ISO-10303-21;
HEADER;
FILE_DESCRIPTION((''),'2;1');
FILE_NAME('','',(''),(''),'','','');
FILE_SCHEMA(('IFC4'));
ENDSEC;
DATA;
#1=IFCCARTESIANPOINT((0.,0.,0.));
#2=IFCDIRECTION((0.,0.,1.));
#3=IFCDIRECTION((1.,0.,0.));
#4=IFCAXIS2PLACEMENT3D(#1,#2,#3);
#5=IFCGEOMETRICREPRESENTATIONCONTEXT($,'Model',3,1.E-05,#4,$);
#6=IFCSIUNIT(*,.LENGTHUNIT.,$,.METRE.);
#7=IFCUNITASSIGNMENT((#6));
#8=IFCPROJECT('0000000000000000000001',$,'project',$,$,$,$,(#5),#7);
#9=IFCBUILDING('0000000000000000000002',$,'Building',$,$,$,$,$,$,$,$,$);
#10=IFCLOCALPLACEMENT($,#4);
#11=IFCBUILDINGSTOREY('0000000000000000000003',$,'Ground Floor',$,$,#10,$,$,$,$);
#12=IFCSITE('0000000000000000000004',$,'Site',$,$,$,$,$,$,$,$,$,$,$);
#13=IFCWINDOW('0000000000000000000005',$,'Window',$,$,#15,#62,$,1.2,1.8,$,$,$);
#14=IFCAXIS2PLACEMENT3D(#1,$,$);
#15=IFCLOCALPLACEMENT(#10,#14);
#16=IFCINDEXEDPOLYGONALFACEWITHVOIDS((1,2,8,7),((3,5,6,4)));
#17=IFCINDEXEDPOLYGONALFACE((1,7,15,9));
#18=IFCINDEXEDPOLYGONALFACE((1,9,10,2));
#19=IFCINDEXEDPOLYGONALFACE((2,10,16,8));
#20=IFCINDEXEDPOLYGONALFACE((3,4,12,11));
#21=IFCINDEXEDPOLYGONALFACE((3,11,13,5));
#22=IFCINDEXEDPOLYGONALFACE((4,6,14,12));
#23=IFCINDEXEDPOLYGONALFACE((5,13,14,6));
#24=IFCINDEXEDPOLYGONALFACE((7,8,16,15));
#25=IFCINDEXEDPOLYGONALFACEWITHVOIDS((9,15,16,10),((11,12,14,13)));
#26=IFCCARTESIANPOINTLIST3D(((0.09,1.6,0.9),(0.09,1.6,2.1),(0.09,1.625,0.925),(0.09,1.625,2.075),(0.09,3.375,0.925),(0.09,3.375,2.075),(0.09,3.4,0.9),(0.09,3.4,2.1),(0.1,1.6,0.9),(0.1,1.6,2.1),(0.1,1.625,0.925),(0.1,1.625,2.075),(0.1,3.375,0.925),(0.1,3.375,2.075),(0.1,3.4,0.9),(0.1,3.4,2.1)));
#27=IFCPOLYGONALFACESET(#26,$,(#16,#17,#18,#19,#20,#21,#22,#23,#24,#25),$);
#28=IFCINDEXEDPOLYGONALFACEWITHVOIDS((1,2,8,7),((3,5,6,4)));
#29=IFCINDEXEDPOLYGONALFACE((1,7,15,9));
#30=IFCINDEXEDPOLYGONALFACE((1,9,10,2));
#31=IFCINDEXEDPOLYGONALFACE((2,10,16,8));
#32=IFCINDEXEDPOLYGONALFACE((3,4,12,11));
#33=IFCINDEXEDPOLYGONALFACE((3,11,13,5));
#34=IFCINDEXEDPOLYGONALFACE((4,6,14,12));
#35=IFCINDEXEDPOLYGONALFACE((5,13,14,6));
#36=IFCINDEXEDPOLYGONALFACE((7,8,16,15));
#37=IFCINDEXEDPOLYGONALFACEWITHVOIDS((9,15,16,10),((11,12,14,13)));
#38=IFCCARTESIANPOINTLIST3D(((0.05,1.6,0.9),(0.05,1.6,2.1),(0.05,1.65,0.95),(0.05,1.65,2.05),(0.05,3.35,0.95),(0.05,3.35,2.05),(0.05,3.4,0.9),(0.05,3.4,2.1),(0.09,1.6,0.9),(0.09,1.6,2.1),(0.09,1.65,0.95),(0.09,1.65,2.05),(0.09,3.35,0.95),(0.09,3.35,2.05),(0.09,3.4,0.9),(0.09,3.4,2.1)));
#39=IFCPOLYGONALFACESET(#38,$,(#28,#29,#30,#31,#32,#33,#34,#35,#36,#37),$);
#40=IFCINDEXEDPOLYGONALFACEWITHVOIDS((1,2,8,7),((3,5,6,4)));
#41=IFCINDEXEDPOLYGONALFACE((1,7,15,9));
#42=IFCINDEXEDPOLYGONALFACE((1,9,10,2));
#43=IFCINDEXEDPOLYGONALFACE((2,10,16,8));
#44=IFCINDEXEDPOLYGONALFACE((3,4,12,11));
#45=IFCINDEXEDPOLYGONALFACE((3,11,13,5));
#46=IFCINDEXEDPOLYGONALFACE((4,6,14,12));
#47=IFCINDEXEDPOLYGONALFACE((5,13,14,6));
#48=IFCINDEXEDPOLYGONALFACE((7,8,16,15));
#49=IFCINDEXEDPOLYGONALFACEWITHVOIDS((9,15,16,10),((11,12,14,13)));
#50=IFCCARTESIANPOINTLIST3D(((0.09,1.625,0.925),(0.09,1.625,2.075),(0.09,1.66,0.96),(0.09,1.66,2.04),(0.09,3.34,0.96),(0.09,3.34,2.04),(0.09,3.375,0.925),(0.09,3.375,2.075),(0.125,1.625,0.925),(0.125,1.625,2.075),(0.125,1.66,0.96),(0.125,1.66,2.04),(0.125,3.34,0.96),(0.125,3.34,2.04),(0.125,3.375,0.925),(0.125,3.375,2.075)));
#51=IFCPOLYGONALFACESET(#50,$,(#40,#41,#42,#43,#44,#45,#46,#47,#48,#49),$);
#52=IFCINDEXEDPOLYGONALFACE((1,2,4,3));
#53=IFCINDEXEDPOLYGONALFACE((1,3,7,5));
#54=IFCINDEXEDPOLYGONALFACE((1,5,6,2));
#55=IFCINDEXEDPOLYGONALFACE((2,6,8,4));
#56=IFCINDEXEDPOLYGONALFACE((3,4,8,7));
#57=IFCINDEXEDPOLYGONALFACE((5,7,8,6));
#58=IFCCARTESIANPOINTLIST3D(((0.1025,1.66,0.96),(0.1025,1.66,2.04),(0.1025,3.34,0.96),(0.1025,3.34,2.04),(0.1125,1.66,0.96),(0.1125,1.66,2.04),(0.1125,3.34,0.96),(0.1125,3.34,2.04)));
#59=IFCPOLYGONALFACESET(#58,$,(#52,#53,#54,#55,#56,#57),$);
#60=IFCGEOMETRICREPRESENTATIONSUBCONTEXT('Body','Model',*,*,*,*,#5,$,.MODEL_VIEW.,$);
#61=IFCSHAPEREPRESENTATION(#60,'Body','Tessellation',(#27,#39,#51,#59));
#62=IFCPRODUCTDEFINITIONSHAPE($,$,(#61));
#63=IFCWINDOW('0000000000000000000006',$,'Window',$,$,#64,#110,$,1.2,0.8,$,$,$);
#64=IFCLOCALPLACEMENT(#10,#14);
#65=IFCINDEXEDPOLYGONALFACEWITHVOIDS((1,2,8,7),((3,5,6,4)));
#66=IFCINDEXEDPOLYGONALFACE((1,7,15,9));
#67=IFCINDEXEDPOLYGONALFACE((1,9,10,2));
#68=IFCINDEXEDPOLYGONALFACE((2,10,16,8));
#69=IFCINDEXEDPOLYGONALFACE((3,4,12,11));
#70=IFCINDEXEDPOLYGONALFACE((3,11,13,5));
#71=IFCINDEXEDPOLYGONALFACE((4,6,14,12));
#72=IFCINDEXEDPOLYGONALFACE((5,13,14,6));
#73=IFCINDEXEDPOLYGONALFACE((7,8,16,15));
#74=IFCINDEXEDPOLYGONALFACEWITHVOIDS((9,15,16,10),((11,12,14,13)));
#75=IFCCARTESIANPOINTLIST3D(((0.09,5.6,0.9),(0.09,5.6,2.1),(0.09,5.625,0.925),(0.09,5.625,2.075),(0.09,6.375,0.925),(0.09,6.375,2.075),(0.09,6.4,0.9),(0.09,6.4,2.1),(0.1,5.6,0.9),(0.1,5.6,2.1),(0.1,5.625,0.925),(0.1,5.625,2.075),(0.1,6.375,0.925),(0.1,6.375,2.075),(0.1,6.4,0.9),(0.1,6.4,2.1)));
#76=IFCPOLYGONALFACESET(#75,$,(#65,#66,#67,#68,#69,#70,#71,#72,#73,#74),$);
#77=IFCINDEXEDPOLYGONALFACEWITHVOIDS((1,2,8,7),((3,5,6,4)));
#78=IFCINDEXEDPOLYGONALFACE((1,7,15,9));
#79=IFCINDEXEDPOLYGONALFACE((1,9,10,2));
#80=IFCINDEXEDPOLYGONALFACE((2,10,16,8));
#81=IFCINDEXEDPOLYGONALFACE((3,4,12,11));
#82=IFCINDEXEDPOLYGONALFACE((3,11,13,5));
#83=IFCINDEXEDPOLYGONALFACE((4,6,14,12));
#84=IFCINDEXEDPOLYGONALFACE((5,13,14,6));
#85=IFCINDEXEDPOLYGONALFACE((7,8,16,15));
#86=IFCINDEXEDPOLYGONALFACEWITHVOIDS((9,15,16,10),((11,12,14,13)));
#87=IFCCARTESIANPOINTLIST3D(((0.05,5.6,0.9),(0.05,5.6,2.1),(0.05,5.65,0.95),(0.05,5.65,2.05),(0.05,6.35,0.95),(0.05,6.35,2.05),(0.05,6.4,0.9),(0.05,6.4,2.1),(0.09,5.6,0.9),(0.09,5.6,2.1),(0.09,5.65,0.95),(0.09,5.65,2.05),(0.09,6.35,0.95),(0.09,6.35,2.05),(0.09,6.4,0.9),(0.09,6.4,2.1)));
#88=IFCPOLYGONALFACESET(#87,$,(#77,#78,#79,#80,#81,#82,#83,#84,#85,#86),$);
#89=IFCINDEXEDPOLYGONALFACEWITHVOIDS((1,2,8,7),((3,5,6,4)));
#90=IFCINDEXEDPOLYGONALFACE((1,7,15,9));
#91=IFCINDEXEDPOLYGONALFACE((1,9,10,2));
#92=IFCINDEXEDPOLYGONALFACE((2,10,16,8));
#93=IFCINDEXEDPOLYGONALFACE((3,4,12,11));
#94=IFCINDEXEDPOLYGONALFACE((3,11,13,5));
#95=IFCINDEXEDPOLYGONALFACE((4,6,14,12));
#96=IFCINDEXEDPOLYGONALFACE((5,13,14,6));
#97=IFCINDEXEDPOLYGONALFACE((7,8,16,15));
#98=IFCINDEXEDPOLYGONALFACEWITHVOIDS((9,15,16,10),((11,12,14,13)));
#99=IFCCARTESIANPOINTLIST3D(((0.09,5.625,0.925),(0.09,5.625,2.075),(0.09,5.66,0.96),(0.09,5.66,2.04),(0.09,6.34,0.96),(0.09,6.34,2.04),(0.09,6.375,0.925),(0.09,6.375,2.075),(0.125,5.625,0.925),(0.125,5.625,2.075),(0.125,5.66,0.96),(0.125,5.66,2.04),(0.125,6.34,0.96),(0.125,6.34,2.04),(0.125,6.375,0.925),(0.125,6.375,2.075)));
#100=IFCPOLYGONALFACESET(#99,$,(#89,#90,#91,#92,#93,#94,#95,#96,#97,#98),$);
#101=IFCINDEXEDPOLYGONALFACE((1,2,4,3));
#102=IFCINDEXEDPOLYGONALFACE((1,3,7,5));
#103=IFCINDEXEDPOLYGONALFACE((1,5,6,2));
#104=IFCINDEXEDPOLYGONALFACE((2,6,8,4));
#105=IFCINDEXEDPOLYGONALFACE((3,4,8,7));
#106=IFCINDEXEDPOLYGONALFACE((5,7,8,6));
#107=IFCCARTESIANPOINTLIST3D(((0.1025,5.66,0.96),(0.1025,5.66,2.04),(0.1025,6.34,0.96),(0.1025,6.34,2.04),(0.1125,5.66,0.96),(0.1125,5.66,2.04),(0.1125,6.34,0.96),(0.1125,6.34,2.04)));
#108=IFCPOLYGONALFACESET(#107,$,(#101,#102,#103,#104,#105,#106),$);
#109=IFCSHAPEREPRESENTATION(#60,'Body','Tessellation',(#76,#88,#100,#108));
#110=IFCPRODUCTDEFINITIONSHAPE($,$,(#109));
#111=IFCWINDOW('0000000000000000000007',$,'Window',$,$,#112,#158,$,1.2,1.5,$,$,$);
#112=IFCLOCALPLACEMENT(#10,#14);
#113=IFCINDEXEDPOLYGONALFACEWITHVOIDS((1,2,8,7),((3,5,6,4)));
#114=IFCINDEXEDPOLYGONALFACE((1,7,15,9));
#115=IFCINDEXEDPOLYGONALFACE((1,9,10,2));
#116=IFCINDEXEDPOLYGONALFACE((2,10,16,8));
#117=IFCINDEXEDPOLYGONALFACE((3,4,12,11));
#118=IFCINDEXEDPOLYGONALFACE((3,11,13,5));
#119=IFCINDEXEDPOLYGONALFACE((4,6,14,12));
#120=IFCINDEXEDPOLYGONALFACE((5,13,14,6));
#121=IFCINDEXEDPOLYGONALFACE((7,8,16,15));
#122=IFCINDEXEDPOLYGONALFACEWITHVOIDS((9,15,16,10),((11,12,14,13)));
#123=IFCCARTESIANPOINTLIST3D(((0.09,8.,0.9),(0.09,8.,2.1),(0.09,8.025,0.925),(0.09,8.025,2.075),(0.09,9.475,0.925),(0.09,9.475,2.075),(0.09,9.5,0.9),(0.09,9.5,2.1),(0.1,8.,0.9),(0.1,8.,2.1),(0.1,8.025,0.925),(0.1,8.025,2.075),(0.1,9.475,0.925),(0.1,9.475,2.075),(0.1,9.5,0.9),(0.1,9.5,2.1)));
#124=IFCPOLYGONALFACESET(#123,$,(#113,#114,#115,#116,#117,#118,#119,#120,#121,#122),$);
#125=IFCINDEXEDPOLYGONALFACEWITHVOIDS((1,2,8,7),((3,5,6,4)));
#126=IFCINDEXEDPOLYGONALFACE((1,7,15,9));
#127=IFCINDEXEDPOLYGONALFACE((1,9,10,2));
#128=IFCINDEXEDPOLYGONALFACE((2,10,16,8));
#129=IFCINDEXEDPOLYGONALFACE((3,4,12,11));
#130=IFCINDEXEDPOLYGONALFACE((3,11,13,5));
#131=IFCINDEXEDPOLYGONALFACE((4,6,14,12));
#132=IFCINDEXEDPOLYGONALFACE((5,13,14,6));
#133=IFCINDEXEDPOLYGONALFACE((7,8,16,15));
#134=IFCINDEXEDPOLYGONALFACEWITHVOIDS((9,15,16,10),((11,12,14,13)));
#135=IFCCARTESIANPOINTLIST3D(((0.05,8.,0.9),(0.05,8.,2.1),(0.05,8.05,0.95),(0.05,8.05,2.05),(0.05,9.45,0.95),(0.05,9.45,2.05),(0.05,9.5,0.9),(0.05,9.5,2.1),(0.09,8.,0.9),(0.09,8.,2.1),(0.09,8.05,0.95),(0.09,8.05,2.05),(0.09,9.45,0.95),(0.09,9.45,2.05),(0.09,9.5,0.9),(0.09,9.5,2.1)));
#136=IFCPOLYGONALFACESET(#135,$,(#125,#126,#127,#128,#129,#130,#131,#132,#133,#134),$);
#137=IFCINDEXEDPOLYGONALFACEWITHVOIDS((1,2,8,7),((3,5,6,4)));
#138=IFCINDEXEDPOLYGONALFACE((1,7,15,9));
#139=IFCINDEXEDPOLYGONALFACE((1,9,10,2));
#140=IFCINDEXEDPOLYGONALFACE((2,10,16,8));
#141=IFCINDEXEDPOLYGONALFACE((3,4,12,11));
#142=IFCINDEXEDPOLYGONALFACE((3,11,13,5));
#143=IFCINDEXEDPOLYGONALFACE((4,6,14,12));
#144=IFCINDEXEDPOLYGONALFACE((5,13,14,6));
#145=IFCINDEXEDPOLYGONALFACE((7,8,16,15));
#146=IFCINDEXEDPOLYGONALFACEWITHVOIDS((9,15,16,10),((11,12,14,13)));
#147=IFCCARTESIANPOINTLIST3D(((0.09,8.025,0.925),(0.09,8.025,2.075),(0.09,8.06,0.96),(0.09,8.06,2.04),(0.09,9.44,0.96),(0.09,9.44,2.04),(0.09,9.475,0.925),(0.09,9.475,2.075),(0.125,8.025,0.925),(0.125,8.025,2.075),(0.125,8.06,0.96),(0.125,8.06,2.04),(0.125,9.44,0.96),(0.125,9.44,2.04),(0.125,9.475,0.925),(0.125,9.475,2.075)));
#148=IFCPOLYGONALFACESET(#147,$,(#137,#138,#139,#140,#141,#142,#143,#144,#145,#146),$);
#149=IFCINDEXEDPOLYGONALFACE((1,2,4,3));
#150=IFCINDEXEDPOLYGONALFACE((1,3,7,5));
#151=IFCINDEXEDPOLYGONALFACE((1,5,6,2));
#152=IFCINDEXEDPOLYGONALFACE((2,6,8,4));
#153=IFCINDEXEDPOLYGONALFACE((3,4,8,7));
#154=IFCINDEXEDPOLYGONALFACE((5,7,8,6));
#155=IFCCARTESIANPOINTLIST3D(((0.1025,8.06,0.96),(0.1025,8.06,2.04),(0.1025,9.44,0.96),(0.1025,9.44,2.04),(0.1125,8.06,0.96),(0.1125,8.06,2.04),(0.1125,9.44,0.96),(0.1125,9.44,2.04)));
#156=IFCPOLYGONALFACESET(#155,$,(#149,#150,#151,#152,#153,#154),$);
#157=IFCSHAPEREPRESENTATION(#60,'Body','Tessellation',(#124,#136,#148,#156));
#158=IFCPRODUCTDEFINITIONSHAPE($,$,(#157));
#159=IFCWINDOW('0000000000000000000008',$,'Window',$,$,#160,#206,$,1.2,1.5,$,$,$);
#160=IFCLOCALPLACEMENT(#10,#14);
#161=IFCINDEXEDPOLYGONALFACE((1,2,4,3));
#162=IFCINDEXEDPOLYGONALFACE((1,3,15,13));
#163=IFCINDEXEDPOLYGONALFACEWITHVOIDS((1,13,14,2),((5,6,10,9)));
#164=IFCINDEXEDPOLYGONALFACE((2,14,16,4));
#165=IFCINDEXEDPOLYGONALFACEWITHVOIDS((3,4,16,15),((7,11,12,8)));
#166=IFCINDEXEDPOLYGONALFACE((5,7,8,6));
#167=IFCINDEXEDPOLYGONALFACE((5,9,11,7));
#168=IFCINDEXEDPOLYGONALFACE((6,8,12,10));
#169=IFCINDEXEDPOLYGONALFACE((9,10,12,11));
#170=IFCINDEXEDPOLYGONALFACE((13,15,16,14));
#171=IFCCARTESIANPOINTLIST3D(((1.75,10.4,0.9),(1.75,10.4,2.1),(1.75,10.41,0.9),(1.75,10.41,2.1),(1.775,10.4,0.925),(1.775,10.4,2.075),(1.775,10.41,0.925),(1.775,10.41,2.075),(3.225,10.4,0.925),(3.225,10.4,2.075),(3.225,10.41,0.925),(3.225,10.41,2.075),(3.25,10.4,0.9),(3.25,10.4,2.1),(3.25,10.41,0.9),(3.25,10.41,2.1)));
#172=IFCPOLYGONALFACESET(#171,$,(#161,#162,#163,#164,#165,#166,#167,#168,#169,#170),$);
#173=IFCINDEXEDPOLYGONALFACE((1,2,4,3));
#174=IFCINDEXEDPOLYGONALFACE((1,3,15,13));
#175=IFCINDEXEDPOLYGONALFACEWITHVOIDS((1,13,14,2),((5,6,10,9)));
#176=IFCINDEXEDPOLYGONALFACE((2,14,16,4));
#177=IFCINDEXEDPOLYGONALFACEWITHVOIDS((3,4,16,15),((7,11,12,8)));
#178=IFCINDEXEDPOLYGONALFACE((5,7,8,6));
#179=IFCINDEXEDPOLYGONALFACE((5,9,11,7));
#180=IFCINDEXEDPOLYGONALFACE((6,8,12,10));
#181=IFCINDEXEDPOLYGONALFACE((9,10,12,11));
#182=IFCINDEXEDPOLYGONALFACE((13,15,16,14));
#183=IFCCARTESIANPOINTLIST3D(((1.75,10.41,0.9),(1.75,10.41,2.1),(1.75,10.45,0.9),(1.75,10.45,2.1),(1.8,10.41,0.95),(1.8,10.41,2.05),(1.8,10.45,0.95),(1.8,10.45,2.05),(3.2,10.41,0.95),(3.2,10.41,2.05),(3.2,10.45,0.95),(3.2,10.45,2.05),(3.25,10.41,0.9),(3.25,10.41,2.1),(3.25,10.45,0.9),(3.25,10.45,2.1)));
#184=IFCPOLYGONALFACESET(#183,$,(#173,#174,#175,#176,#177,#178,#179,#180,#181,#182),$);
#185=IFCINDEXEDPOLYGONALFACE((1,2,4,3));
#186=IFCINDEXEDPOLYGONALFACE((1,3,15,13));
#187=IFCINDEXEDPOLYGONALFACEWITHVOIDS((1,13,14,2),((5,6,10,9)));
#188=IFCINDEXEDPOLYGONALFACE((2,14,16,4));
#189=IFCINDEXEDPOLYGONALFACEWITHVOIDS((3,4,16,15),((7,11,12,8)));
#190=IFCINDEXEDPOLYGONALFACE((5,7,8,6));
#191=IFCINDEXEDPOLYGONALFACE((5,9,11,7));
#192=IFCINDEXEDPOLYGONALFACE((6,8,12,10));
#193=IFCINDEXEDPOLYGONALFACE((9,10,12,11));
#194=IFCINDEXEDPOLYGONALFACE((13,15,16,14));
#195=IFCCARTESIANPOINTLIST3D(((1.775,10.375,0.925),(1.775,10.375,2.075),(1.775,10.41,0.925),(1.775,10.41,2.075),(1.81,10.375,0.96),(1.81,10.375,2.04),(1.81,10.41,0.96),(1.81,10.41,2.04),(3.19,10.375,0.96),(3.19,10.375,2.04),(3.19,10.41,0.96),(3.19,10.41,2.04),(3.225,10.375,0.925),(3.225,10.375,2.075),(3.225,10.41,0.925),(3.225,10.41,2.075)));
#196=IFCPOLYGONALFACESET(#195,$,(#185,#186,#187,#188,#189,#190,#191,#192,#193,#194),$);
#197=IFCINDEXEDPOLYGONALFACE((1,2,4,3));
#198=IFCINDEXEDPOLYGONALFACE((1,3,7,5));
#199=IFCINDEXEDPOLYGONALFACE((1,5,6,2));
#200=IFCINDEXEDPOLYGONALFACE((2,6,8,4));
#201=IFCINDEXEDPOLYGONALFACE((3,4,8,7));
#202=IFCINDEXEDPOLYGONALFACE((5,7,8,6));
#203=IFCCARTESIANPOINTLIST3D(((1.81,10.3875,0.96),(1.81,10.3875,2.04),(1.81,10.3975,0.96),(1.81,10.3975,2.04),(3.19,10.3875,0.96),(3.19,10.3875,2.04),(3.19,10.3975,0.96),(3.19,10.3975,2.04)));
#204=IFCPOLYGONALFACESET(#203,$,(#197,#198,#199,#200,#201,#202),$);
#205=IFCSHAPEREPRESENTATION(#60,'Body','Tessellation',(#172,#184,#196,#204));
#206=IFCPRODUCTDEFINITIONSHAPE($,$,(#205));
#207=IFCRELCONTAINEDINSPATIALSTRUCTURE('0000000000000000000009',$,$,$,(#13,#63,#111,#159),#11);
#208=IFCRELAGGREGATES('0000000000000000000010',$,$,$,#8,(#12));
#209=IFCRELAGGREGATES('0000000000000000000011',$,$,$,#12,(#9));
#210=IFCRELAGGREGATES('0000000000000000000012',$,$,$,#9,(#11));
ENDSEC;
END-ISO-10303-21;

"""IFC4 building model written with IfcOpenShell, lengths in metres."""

from ifc_helpers import new_model, si_unit, frame, origin_with_axes, place, context, subcontext, project, spatial, line, indexed_curve, outline, extrude, element, save


model = new_model("IFC4")

# Units and contexts
model_context = context("Model", 3, precision=1e-05, world=origin_with_axes())
body_context = subcontext(model_context, "Body", "Model", "MODEL_VIEW")
ifc_project = project(units=[si_unit("LENGTHUNIT", "METRE")], contexts=[model_context])

# Site, building, storey
site = spatial("IfcSite", under=ifc_project, Name="Site")
building = spatial("IfcBuilding", under=site, Name="Building")
storey_placement = place(None, origin_with_axes())
storey = spatial("IfcBuildingStorey", under=building, at=storey_placement, Name="Ground Floor")

# Windows
window_1_placement = place(storey_placement, frame((0.0, 3.4, 0.9), z_axis=(0.0, 0.0, 1.0), x_axis=(0.0, -1.0, 0.0)))
element("IfcWindow", 1, at=window_1_placement, inside=storey, Name="Window", OverallHeight=1.2, OverallWidth=1.8, context=body_context, shape_type="SweptSolid", body=[
    extrude(outline(indexed_curve([(0.0, 0.0), (1.8, 0.0), (1.8, 1.2), (0.0, 1.2)], segments=[line(1, 2, 3, 4, 1)]), holes=[indexed_curve([(0.025, 0.025), (1.775, 0.025), (1.775, 1.175), (0.025, 1.175)], segments=[line(1, 2, 3, 4, 1)])]), frame((0.0, 0.09, 0.0), z_axis=(0.0, -1.0, 0.0), x_axis=(1.0, 0.0, 0.0)), (0.0, 0.0, -1.0), 0.01),
    extrude(outline(indexed_curve([(0.0, 0.0), (1.8, 0.0), (1.8, 1.2), (0.0, 1.2)], segments=[line(1, 2, 3, 4, 1)]), holes=[indexed_curve([(0.05, 0.05), (1.75, 0.05), (1.75, 1.15), (0.05, 1.15)], segments=[line(1, 2, 3, 4, 1)])]), frame((0.0, 0.05, 0.0), z_axis=(0.0, -1.0, 0.0), x_axis=(1.0, 0.0, 0.0)), (0.0, 0.0, -1.0), 0.04),
    extrude(outline(indexed_curve([(0.0, 0.0), (1.75, 0.0), (1.75, 1.15), (0.0, 1.15)], segments=[line(1, 2, 3, 4, 1)]), holes=[indexed_curve([(0.035, 0.035), (1.715, 0.035), (1.715, 1.115), (0.035, 1.115)], segments=[line(1, 2, 3, 4, 1)])]), frame((0.025, 0.09, 0.025), z_axis=(0.0, -1.0, 0.0), x_axis=(1.0, 0.0, 0.0)), (0.0, 0.0, -1.0), 0.035),
    extrude(outline(indexed_curve([(0.035, 0.035), (1.715, 0.035), (1.715, 1.115), (0.035, 1.115)], segments=[line(1, 2, 3, 4, 1)])), frame((0.025, 0.1025, 0.025), z_axis=(0.0, -1.0, 0.0), x_axis=(1.0, 0.0, 0.0)), (0.0, 0.0, -1.0), 0.01),
])
window_2_placement = place(storey_placement, frame((0.0, 6.4, 0.9), z_axis=(0.0, 0.0, 1.0), x_axis=(0.0, -1.0, 0.0)))
element("IfcWindow", 2, at=window_2_placement, inside=storey, Name="Window", OverallHeight=1.2, OverallWidth=0.8, context=body_context, shape_type="SweptSolid", body=[
    extrude(outline(indexed_curve([(0.0, 0.0), (0.8, 0.0), (0.8, 1.2), (0.0, 1.2)], segments=[line(1, 2, 3, 4, 1)]), holes=[indexed_curve([(0.025, 0.025), (0.775, 0.025), (0.775, 1.175), (0.025, 1.175)], segments=[line(1, 2, 3, 4, 1)])]), frame((0.0, 0.09, 0.0), z_axis=(0.0, -1.0, 0.0), x_axis=(1.0, 0.0, 0.0)), (0.0, 0.0, -1.0), 0.01),
    extrude(outline(indexed_curve([(0.0, 0.0), (0.8, 0.0), (0.8, 1.2), (0.0, 1.2)], segments=[line(1, 2, 3, 4, 1)]), holes=[indexed_curve([(0.05, 0.05), (0.75, 0.05), (0.75, 1.15), (0.05, 1.15)], segments=[line(1, 2, 3, 4, 1)])]), frame((0.0, 0.05, 0.0), z_axis=(0.0, -1.0, 0.0), x_axis=(1.0, 0.0, 0.0)), (0.0, 0.0, -1.0), 0.04),
    extrude(outline(indexed_curve([(0.0, 0.0), (0.75, 0.0), (0.75, 1.15), (0.0, 1.15)], segments=[line(1, 2, 3, 4, 1)]), holes=[indexed_curve([(0.035, 0.035), (0.715, 0.035), (0.715, 1.115), (0.035, 1.115)], segments=[line(1, 2, 3, 4, 1)])]), frame((0.025, 0.09, 0.025), z_axis=(0.0, -1.0, 0.0), x_axis=(1.0, 0.0, 0.0)), (0.0, 0.0, -1.0), 0.035),
    extrude(outline(indexed_curve([(0.035, 0.035), (0.715, 0.035), (0.715, 1.115), (0.035, 1.115)], segments=[line(1, 2, 3, 4, 1)])), frame((0.025, 0.1025, 0.025), z_axis=(0.0, -1.0, 0.0), x_axis=(1.0, 0.0, 0.0)), (0.0, 0.0, -1.0), 0.01),
])
for number, where, z_axis, x_axis, name in (
    (3, (0.0, 9.5, 0.9), (0.0, 0.0, 1.0), (0.0, -1.0, 0.0), "Window"),
    (4, (3.25, 10.5, 0.9), (0.0, 0.0, 1.0), (-1.0, 0.0, 0.0), "Window"),
):
    element("IfcWindow", number, at=place(storey_placement, frame(where, z_axis=z_axis, x_axis=x_axis)), inside=storey, Name=name, OverallHeight=1.2, OverallWidth=1.5, context=body_context, shape_type="SweptSolid", body=[
        extrude(outline(indexed_curve([(0.0, 0.0), (1.5, 0.0), (1.5, 1.2), (0.0, 1.2)], segments=[line(1, 2, 3, 4, 1)]), holes=[indexed_curve([(0.025, 0.025), (1.475, 0.025), (1.475, 1.175), (0.025, 1.175)], segments=[line(1, 2, 3, 4, 1)])]), frame((0.0, 0.09, 0.0), z_axis=(0.0, -1.0, 0.0), x_axis=(1.0, 0.0, 0.0)), (0.0, 0.0, -1.0), 0.01),
        extrude(outline(indexed_curve([(0.0, 0.0), (1.5, 0.0), (1.5, 1.2), (0.0, 1.2)], segments=[line(1, 2, 3, 4, 1)]), holes=[indexed_curve([(0.05, 0.05), (1.45, 0.05), (1.45, 1.15), (0.05, 1.15)], segments=[line(1, 2, 3, 4, 1)])]), frame((0.0, 0.05, 0.0), z_axis=(0.0, -1.0, 0.0), x_axis=(1.0, 0.0, 0.0)), (0.0, 0.0, -1.0), 0.04),
        extrude(outline(indexed_curve([(0.0, 0.0), (1.45, 0.0), (1.45, 1.15), (0.0, 1.15)], segments=[line(1, 2, 3, 4, 1)]), holes=[indexed_curve([(0.035, 0.035), (1.415, 0.035), (1.415, 1.115), (0.035, 1.115)], segments=[line(1, 2, 3, 4, 1)])]), frame((0.025, 0.09, 0.025), z_axis=(0.0, -1.0, 0.0), x_axis=(1.0, 0.0, 0.0)), (0.0, 0.0, -1.0), 0.035),
        extrude(outline(indexed_curve([(0.035, 0.035), (1.415, 0.035), (1.415, 1.115), (0.035, 1.115)], segments=[line(1, 2, 3, 4, 1)])), frame((0.025, 0.1025, 0.025), z_axis=(0.0, -1.0, 0.0), x_axis=(1.0, 0.0, 0.0)), (0.0, 0.0, -1.0), 0.01),
    ])

save(model, "model.ifc")
